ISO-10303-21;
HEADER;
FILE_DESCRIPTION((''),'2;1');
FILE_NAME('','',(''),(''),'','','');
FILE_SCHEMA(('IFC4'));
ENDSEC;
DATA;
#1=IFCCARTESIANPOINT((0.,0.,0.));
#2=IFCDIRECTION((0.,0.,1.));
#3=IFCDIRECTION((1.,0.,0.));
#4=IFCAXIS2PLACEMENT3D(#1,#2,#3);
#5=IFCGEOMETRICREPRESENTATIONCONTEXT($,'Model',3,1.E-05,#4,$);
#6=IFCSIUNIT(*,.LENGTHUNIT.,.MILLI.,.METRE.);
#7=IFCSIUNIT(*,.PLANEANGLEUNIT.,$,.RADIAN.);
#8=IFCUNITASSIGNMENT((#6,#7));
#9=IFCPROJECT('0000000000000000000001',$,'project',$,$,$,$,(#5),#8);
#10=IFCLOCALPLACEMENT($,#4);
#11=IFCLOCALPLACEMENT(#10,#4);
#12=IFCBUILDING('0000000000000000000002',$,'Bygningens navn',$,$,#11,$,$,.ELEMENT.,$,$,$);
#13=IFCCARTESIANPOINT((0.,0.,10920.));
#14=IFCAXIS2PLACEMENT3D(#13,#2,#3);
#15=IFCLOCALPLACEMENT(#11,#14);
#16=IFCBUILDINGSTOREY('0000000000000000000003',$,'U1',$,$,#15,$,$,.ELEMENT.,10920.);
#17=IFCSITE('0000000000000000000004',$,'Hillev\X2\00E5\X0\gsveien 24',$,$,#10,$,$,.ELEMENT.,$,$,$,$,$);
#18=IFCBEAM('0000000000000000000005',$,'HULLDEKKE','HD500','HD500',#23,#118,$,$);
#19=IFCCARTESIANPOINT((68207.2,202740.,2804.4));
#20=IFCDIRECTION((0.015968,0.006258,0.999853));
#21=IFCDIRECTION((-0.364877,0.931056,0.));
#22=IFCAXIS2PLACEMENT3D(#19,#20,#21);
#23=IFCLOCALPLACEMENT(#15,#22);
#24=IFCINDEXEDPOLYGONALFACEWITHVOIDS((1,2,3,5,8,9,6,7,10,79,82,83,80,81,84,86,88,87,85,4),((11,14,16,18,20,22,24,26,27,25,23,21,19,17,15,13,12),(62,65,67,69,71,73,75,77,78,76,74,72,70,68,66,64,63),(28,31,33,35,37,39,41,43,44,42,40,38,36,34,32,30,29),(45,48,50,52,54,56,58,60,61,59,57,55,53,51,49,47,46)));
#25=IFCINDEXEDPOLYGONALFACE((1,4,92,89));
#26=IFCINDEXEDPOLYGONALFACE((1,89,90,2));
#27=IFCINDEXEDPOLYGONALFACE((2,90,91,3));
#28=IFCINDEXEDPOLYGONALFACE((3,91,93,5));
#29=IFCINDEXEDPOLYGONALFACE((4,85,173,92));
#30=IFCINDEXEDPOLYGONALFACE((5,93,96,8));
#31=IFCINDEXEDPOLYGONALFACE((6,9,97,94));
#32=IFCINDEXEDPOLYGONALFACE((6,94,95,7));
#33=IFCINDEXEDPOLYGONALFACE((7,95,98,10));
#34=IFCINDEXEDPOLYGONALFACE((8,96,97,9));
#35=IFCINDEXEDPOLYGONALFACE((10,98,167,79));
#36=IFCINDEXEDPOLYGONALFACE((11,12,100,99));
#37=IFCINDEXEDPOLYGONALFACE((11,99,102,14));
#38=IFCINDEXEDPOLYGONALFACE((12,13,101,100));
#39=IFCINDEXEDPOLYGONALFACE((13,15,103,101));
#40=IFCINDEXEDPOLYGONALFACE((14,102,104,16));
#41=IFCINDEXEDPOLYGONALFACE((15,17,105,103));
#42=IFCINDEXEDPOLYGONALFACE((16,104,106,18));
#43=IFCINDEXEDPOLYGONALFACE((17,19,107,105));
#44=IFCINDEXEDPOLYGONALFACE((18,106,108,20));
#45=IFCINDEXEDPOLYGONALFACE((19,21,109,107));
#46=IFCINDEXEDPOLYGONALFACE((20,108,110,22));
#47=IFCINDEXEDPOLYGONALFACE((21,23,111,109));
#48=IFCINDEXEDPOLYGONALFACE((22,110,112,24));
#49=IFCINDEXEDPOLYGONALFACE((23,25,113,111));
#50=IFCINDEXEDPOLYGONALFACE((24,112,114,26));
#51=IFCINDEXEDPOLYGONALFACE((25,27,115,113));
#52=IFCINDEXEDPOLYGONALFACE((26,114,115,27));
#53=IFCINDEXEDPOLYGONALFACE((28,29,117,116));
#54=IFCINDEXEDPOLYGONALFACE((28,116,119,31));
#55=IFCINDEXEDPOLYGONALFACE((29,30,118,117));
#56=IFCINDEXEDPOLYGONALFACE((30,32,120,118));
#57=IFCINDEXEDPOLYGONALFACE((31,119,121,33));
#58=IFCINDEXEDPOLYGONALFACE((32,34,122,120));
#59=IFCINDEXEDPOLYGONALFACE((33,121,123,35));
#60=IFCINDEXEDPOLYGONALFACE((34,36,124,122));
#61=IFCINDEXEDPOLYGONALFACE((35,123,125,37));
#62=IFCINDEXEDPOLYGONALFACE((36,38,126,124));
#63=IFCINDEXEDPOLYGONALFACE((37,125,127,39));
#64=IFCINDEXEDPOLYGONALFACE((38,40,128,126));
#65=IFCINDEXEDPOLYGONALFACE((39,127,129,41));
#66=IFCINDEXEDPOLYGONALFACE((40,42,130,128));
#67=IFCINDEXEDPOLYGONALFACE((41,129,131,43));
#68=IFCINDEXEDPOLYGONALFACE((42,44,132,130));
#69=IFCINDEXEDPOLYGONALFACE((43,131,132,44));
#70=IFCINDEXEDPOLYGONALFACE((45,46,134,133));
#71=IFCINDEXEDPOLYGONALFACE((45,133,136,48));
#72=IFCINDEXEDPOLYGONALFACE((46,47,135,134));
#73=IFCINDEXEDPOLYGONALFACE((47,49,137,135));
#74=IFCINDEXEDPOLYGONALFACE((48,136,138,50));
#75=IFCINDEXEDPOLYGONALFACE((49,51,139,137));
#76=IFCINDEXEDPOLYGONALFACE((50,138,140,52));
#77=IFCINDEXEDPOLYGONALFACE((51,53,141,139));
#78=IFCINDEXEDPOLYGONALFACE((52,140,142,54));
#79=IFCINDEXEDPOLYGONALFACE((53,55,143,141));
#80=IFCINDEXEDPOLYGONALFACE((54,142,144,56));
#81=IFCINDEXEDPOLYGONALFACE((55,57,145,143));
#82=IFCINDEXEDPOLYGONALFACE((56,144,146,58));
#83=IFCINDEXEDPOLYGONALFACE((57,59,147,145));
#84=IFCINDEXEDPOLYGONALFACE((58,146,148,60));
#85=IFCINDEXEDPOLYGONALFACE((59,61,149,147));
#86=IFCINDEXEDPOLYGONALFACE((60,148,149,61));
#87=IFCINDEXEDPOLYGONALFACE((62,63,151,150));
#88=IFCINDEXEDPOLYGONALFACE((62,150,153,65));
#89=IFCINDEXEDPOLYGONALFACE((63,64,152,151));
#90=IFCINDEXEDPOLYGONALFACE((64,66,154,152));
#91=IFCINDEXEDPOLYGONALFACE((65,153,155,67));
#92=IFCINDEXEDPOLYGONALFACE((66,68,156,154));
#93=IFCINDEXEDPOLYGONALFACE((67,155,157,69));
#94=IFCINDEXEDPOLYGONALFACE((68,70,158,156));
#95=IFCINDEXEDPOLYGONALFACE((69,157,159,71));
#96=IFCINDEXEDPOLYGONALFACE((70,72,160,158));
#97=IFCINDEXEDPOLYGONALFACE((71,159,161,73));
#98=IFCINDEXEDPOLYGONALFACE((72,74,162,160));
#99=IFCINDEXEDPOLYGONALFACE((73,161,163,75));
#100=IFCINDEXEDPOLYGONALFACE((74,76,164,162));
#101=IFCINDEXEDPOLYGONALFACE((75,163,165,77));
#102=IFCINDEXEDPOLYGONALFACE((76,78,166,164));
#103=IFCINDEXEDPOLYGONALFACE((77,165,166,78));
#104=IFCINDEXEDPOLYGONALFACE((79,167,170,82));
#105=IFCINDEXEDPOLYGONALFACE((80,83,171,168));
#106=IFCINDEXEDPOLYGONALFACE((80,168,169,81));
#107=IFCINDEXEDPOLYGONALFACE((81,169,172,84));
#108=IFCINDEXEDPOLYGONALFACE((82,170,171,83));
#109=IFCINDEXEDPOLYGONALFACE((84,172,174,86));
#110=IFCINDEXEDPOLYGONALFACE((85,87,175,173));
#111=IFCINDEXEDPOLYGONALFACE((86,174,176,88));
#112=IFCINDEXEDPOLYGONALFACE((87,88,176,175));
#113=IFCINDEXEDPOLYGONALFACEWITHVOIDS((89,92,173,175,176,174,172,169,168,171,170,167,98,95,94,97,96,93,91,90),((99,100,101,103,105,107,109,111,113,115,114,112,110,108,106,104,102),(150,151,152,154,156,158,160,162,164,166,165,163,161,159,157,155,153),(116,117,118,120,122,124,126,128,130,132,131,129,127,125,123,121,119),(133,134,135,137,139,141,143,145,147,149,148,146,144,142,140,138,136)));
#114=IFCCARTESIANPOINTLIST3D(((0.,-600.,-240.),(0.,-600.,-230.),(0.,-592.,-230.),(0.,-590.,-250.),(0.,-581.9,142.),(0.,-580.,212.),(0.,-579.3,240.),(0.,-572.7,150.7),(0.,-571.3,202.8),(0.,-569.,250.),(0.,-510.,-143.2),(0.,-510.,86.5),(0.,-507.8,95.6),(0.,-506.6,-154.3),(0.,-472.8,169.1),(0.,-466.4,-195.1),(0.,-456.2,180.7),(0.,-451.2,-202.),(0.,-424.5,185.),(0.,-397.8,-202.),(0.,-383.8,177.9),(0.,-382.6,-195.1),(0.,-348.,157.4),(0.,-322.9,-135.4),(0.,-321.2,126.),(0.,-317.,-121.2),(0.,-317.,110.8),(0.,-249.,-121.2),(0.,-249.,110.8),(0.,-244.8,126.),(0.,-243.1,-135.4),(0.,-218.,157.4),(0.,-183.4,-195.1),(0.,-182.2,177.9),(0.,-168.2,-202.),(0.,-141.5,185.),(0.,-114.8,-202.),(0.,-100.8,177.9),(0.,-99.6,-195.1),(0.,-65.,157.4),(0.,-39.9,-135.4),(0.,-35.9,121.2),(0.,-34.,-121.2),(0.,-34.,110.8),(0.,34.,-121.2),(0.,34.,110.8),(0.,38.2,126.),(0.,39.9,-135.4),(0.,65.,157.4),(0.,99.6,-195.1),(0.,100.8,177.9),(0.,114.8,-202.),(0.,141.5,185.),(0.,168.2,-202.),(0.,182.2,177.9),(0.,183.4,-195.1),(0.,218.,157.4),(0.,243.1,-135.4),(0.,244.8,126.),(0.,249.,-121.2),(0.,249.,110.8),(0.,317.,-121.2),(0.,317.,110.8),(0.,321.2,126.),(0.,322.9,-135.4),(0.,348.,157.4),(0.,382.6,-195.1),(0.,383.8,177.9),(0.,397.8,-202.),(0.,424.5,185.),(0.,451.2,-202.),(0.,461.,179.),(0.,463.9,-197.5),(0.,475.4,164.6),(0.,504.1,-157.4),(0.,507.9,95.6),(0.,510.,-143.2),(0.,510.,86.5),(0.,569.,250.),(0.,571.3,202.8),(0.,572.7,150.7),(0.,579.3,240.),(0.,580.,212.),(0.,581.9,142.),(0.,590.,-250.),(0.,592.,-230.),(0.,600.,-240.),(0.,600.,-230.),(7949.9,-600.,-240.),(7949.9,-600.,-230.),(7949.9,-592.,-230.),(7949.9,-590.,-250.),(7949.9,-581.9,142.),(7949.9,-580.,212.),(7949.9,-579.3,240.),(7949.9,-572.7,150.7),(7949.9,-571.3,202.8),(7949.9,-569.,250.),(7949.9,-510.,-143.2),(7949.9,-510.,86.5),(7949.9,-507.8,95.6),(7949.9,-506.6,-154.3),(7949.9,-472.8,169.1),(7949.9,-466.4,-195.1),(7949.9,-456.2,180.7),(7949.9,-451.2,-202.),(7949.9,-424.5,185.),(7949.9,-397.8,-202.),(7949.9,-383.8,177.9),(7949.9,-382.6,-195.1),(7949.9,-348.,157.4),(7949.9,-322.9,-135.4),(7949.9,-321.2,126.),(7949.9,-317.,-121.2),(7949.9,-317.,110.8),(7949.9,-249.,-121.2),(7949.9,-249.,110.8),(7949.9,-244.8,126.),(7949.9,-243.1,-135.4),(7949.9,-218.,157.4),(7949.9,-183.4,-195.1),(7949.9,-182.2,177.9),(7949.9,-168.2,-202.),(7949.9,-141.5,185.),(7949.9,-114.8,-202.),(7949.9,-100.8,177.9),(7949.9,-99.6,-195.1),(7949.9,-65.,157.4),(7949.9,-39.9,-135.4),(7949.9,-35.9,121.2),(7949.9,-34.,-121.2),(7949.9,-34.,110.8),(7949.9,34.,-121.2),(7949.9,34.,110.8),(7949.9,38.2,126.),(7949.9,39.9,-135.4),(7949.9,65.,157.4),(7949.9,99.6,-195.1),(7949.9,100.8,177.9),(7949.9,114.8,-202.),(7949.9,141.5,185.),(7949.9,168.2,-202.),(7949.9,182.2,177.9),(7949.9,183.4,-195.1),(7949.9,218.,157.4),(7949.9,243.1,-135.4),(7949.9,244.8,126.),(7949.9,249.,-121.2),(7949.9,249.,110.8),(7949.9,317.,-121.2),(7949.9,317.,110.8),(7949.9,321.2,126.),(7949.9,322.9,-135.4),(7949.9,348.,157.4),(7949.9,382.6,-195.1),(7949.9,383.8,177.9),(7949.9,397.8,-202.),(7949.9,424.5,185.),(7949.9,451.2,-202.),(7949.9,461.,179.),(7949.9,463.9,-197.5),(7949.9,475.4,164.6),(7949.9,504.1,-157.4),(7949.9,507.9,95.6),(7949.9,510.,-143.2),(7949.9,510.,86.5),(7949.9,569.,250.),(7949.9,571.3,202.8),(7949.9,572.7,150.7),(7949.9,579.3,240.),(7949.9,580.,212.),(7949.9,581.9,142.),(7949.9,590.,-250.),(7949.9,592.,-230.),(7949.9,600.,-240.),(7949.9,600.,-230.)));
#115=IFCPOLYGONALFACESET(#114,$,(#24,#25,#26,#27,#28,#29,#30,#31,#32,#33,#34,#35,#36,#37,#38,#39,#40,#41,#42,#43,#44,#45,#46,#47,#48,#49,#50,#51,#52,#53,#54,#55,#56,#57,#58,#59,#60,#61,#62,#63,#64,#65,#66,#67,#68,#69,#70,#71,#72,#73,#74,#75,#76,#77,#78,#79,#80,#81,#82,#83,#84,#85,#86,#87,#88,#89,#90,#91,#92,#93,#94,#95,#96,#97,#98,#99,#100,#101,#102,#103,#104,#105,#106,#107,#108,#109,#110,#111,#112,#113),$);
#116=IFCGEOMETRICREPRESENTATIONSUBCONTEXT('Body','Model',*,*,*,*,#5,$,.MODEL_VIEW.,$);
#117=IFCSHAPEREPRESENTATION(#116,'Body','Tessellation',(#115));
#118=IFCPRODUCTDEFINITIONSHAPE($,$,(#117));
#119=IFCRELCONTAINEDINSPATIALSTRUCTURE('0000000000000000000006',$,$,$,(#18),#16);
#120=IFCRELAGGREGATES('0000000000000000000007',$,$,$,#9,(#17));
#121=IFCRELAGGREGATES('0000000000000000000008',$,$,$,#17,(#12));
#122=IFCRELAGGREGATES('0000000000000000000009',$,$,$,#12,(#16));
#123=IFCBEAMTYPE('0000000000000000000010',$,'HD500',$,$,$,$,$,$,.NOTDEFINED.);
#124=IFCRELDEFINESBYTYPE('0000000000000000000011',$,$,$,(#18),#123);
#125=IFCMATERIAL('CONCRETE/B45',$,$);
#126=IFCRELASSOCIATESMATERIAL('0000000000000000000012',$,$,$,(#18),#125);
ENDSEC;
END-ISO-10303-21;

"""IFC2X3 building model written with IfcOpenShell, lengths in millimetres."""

from ifc_helpers import new_model, si_unit, frame, origin_with_axes, place, context, subcontext, project, spatial, polyline, outline, extrude, material, type_object, element, save


model = new_model("IFC2X3")

# Units and contexts
model_context = context("Model", 3, precision=1e-05, world=origin_with_axes())
body_context = subcontext(model_context, "Body", "Model", "MODEL_VIEW")
ifc_project = project(units=[si_unit("LENGTHUNIT", "METRE", prefix="MILLI"), si_unit("PLANEANGLEUNIT", "RADIAN")], contexts=[model_context])

# Site, building, storey
site_placement = place(None, origin_with_axes())
site = spatial("IfcSite", under=ifc_project, at=site_placement, Name="Hillevågsveien 24", CompositionType="ELEMENT")
building_placement = place(site_placement, origin_with_axes())
building = spatial("IfcBuilding", under=site, at=building_placement, Name="Bygningens navn", CompositionType="ELEMENT")
storey_placement = place(building_placement, frame((0.0, 0.0, 10920.0), z_axis=(0.0, 0.0, 1.0), x_axis=(1.0, 0.0, 0.0)))
storey = spatial("IfcBuildingStorey", under=building, at=storey_placement, Name="U1", CompositionType="ELEMENT", Elevation=10920.0)

# Beam
ifc_material_1 = material(Name="CONCRETE/B45")
beam_type_1 = type_object("IfcBeamType", Name="HD500", PredefinedType="NOTDEFINED")
beam_1_placement = place(storey_placement, frame((68207.2, 202740.0, 2804.4), z_axis=(0.015968, 0.006258, 0.999853), x_axis=(-0.364877, 0.931056, 0.0)))
element("IfcBeam", 1, at=beam_1_placement, inside=storey, type_object=beam_type_1, material=ifc_material_1, Name="HULLDEKKE", Description="HD500", ObjectType="HD500", context=body_context, shape_type="SweptSolid", body=[
    extrude(outline(polyline([(581.9, 142.0), (592.0, -230.0), (600.0, -230.0), (600.0, -240.0), (590.0, -250.0), (-590.0, -250.0), (-600.0, -240.0), (-600.0, -230.0), (-592.0, -230.0), (-581.9, 142.0), (-572.7, 150.7), (-571.3, 202.8), (-580.0, 212.0), (-579.3, 240.0), (-569.0, 250.0), (569.0, 250.0), (579.3, 240.0), (580.0, 212.0), (571.3, 202.8), (572.7, 150.7), (581.9, 142.0)]), holes=[polyline([(466.4, -195.1), (506.6, -154.3), (510.0, -143.2), (510.0, 86.5), (507.8, 95.6), (472.8, 169.1), (456.2, 180.7), (424.5, 185.0), (383.8, 177.9), (348.0, 157.4), (321.2, 126.0), (317.0, 110.8), (317.0, -121.2), (322.9, -135.4), (382.6, -195.1), (397.8, -202.0), (451.2, -202.0), (466.4, -195.1)]), polyline([(183.4, -195.1), (243.1, -135.4), (249.0, -121.2), (249.0, 110.8), (244.8, 126.0), (218.0, 157.4), (182.2, 177.9), (141.5, 185.0), (100.8, 177.9), (65.0, 157.4), (35.9, 121.2), (34.0, 110.8), (34.0, -121.2), (39.9, -135.4), (99.6, -195.1), (114.8, -202.0), (168.2, -202.0), (183.4, -195.1)]), polyline([(-99.6, -195.1), (-39.9, -135.4), (-34.0, -121.2), (-34.0, 110.8), (-38.2, 126.0), (-65.0, 157.4), (-100.8, 177.9), (-141.5, 185.0), (-182.2, 177.9), (-218.0, 157.4), (-244.8, 126.0), (-249.0, 110.8), (-249.0, -121.2), (-243.1, -135.4), (-183.4, -195.1), (-168.2, -202.0), (-114.8, -202.0), (-99.6, -195.1)]), polyline([(-382.6, -195.1), (-322.9, -135.4), (-317.0, -121.2), (-317.0, 110.8), (-321.2, 126.0), (-348.0, 157.4), (-383.8, 177.9), (-424.5, 185.0), (-461.0, 179.0), (-475.4, 164.6), (-507.9, 95.6), (-510.0, 86.5), (-510.0, -143.2), (-504.1, -157.4), (-463.9, -197.5), (-451.2, -202.0), (-397.8, -202.0), (-382.6, -195.1)])]), frame((7949.9, 0.0, 0.0), z_axis=(-1.0, 0.0, 0.0), x_axis=(0.0, -1.0, 0.0)), (0.0, 0.0, 1.0), 7949.9),
])

save(model, "model.ifc")
